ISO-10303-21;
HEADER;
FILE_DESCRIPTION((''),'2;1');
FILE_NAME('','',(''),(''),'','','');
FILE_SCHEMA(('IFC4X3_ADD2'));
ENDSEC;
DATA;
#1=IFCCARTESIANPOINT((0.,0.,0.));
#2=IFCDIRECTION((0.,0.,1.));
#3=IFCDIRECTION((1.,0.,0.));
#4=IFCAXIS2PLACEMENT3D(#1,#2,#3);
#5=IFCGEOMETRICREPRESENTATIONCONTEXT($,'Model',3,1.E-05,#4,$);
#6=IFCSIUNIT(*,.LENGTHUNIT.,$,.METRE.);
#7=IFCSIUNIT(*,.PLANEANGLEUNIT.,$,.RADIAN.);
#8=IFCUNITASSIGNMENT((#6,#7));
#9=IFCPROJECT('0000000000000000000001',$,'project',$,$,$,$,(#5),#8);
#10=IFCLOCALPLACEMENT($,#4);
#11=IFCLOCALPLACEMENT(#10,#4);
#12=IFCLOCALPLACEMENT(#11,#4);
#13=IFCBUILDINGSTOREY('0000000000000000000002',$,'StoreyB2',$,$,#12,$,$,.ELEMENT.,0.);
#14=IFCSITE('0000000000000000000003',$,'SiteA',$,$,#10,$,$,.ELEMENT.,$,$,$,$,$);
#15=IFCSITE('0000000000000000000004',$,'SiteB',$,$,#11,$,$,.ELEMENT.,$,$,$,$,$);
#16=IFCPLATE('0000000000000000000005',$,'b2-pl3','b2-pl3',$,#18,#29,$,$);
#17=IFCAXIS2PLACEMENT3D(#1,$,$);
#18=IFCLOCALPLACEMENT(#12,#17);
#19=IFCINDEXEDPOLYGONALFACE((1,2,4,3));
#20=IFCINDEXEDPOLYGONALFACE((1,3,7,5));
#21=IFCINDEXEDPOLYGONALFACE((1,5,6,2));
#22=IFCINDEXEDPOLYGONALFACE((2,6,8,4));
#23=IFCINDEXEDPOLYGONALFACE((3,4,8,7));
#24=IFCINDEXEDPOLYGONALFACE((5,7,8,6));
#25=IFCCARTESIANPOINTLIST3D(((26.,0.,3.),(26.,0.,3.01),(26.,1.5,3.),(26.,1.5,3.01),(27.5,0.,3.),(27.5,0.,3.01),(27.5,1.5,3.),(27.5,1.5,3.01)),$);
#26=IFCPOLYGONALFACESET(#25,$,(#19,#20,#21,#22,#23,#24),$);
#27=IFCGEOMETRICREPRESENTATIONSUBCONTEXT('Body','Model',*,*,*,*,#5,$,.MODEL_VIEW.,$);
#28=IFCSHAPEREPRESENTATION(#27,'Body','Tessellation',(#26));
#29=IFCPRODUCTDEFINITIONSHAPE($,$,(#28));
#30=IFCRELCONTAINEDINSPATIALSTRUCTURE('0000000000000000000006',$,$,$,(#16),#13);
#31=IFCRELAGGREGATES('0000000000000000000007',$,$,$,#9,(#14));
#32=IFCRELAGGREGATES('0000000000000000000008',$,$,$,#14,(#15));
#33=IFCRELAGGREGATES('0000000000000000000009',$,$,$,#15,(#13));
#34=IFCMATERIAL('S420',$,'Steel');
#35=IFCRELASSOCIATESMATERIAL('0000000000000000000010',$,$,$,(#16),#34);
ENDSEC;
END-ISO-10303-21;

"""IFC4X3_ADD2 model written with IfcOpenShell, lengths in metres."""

from ifc_helpers import new_model, si_unit, frame, origin_with_axes, place, context, subcontext, project, spatial, line, indexed_curve, outline, extrude, material, element, save


model = new_model("IFC4X3_ADD2")

# Units and contexts
model_context = context("Model", 3, precision=1e-05, world=origin_with_axes())
body_context = subcontext(model_context, "Body", "Model", "MODEL_VIEW")
ifc_project = project(units=[si_unit("LENGTHUNIT", "METRE"), si_unit("PLANEANGLEUNIT", "RADIAN")], contexts=[model_context])

# Sites, storey
site_1_placement = place(None, origin_with_axes())
site_1 = spatial("IfcSite", under=ifc_project, at=site_1_placement, Name="SiteA", CompositionType="ELEMENT")
site_2_placement = place(site_1_placement, origin_with_axes())
site_2 = spatial("IfcSite", under=site_1, at=site_2_placement, Name="SiteB", CompositionType="ELEMENT")
storey_placement = place(site_2_placement, origin_with_axes())
storey = spatial("IfcBuildingStorey", under=site_2, at=storey_placement, Name="StoreyB2", CompositionType="ELEMENT", Elevation=0.0)

# Plate
ifc_material_1 = material(Name="S420", Category="Steel")
plate_1_placement = place(None, origin_with_axes())
element("IfcPlate", 1, at=plate_1_placement, inside=storey, material=ifc_material_1, Name="b2-pl3", Description="b2-pl3", context=body_context, shape_type="SolidModel", body=[
    extrude(outline(indexed_curve([(26.0, 0.0), (26.0, 1.5), (27.5, 0.0), (27.5, 1.5)], segments=[line(3, 1), line(1, 2), line(2, 4), line(4, 3)])), frame((0.0, 0.0, 3.0), z_axis=(0.0, 0.0, 1.0), x_axis=(1.0, 0.0, 0.0)), (0.0, 0.0, 1.0), 0.01),
])

save(model, "model.ifc")
